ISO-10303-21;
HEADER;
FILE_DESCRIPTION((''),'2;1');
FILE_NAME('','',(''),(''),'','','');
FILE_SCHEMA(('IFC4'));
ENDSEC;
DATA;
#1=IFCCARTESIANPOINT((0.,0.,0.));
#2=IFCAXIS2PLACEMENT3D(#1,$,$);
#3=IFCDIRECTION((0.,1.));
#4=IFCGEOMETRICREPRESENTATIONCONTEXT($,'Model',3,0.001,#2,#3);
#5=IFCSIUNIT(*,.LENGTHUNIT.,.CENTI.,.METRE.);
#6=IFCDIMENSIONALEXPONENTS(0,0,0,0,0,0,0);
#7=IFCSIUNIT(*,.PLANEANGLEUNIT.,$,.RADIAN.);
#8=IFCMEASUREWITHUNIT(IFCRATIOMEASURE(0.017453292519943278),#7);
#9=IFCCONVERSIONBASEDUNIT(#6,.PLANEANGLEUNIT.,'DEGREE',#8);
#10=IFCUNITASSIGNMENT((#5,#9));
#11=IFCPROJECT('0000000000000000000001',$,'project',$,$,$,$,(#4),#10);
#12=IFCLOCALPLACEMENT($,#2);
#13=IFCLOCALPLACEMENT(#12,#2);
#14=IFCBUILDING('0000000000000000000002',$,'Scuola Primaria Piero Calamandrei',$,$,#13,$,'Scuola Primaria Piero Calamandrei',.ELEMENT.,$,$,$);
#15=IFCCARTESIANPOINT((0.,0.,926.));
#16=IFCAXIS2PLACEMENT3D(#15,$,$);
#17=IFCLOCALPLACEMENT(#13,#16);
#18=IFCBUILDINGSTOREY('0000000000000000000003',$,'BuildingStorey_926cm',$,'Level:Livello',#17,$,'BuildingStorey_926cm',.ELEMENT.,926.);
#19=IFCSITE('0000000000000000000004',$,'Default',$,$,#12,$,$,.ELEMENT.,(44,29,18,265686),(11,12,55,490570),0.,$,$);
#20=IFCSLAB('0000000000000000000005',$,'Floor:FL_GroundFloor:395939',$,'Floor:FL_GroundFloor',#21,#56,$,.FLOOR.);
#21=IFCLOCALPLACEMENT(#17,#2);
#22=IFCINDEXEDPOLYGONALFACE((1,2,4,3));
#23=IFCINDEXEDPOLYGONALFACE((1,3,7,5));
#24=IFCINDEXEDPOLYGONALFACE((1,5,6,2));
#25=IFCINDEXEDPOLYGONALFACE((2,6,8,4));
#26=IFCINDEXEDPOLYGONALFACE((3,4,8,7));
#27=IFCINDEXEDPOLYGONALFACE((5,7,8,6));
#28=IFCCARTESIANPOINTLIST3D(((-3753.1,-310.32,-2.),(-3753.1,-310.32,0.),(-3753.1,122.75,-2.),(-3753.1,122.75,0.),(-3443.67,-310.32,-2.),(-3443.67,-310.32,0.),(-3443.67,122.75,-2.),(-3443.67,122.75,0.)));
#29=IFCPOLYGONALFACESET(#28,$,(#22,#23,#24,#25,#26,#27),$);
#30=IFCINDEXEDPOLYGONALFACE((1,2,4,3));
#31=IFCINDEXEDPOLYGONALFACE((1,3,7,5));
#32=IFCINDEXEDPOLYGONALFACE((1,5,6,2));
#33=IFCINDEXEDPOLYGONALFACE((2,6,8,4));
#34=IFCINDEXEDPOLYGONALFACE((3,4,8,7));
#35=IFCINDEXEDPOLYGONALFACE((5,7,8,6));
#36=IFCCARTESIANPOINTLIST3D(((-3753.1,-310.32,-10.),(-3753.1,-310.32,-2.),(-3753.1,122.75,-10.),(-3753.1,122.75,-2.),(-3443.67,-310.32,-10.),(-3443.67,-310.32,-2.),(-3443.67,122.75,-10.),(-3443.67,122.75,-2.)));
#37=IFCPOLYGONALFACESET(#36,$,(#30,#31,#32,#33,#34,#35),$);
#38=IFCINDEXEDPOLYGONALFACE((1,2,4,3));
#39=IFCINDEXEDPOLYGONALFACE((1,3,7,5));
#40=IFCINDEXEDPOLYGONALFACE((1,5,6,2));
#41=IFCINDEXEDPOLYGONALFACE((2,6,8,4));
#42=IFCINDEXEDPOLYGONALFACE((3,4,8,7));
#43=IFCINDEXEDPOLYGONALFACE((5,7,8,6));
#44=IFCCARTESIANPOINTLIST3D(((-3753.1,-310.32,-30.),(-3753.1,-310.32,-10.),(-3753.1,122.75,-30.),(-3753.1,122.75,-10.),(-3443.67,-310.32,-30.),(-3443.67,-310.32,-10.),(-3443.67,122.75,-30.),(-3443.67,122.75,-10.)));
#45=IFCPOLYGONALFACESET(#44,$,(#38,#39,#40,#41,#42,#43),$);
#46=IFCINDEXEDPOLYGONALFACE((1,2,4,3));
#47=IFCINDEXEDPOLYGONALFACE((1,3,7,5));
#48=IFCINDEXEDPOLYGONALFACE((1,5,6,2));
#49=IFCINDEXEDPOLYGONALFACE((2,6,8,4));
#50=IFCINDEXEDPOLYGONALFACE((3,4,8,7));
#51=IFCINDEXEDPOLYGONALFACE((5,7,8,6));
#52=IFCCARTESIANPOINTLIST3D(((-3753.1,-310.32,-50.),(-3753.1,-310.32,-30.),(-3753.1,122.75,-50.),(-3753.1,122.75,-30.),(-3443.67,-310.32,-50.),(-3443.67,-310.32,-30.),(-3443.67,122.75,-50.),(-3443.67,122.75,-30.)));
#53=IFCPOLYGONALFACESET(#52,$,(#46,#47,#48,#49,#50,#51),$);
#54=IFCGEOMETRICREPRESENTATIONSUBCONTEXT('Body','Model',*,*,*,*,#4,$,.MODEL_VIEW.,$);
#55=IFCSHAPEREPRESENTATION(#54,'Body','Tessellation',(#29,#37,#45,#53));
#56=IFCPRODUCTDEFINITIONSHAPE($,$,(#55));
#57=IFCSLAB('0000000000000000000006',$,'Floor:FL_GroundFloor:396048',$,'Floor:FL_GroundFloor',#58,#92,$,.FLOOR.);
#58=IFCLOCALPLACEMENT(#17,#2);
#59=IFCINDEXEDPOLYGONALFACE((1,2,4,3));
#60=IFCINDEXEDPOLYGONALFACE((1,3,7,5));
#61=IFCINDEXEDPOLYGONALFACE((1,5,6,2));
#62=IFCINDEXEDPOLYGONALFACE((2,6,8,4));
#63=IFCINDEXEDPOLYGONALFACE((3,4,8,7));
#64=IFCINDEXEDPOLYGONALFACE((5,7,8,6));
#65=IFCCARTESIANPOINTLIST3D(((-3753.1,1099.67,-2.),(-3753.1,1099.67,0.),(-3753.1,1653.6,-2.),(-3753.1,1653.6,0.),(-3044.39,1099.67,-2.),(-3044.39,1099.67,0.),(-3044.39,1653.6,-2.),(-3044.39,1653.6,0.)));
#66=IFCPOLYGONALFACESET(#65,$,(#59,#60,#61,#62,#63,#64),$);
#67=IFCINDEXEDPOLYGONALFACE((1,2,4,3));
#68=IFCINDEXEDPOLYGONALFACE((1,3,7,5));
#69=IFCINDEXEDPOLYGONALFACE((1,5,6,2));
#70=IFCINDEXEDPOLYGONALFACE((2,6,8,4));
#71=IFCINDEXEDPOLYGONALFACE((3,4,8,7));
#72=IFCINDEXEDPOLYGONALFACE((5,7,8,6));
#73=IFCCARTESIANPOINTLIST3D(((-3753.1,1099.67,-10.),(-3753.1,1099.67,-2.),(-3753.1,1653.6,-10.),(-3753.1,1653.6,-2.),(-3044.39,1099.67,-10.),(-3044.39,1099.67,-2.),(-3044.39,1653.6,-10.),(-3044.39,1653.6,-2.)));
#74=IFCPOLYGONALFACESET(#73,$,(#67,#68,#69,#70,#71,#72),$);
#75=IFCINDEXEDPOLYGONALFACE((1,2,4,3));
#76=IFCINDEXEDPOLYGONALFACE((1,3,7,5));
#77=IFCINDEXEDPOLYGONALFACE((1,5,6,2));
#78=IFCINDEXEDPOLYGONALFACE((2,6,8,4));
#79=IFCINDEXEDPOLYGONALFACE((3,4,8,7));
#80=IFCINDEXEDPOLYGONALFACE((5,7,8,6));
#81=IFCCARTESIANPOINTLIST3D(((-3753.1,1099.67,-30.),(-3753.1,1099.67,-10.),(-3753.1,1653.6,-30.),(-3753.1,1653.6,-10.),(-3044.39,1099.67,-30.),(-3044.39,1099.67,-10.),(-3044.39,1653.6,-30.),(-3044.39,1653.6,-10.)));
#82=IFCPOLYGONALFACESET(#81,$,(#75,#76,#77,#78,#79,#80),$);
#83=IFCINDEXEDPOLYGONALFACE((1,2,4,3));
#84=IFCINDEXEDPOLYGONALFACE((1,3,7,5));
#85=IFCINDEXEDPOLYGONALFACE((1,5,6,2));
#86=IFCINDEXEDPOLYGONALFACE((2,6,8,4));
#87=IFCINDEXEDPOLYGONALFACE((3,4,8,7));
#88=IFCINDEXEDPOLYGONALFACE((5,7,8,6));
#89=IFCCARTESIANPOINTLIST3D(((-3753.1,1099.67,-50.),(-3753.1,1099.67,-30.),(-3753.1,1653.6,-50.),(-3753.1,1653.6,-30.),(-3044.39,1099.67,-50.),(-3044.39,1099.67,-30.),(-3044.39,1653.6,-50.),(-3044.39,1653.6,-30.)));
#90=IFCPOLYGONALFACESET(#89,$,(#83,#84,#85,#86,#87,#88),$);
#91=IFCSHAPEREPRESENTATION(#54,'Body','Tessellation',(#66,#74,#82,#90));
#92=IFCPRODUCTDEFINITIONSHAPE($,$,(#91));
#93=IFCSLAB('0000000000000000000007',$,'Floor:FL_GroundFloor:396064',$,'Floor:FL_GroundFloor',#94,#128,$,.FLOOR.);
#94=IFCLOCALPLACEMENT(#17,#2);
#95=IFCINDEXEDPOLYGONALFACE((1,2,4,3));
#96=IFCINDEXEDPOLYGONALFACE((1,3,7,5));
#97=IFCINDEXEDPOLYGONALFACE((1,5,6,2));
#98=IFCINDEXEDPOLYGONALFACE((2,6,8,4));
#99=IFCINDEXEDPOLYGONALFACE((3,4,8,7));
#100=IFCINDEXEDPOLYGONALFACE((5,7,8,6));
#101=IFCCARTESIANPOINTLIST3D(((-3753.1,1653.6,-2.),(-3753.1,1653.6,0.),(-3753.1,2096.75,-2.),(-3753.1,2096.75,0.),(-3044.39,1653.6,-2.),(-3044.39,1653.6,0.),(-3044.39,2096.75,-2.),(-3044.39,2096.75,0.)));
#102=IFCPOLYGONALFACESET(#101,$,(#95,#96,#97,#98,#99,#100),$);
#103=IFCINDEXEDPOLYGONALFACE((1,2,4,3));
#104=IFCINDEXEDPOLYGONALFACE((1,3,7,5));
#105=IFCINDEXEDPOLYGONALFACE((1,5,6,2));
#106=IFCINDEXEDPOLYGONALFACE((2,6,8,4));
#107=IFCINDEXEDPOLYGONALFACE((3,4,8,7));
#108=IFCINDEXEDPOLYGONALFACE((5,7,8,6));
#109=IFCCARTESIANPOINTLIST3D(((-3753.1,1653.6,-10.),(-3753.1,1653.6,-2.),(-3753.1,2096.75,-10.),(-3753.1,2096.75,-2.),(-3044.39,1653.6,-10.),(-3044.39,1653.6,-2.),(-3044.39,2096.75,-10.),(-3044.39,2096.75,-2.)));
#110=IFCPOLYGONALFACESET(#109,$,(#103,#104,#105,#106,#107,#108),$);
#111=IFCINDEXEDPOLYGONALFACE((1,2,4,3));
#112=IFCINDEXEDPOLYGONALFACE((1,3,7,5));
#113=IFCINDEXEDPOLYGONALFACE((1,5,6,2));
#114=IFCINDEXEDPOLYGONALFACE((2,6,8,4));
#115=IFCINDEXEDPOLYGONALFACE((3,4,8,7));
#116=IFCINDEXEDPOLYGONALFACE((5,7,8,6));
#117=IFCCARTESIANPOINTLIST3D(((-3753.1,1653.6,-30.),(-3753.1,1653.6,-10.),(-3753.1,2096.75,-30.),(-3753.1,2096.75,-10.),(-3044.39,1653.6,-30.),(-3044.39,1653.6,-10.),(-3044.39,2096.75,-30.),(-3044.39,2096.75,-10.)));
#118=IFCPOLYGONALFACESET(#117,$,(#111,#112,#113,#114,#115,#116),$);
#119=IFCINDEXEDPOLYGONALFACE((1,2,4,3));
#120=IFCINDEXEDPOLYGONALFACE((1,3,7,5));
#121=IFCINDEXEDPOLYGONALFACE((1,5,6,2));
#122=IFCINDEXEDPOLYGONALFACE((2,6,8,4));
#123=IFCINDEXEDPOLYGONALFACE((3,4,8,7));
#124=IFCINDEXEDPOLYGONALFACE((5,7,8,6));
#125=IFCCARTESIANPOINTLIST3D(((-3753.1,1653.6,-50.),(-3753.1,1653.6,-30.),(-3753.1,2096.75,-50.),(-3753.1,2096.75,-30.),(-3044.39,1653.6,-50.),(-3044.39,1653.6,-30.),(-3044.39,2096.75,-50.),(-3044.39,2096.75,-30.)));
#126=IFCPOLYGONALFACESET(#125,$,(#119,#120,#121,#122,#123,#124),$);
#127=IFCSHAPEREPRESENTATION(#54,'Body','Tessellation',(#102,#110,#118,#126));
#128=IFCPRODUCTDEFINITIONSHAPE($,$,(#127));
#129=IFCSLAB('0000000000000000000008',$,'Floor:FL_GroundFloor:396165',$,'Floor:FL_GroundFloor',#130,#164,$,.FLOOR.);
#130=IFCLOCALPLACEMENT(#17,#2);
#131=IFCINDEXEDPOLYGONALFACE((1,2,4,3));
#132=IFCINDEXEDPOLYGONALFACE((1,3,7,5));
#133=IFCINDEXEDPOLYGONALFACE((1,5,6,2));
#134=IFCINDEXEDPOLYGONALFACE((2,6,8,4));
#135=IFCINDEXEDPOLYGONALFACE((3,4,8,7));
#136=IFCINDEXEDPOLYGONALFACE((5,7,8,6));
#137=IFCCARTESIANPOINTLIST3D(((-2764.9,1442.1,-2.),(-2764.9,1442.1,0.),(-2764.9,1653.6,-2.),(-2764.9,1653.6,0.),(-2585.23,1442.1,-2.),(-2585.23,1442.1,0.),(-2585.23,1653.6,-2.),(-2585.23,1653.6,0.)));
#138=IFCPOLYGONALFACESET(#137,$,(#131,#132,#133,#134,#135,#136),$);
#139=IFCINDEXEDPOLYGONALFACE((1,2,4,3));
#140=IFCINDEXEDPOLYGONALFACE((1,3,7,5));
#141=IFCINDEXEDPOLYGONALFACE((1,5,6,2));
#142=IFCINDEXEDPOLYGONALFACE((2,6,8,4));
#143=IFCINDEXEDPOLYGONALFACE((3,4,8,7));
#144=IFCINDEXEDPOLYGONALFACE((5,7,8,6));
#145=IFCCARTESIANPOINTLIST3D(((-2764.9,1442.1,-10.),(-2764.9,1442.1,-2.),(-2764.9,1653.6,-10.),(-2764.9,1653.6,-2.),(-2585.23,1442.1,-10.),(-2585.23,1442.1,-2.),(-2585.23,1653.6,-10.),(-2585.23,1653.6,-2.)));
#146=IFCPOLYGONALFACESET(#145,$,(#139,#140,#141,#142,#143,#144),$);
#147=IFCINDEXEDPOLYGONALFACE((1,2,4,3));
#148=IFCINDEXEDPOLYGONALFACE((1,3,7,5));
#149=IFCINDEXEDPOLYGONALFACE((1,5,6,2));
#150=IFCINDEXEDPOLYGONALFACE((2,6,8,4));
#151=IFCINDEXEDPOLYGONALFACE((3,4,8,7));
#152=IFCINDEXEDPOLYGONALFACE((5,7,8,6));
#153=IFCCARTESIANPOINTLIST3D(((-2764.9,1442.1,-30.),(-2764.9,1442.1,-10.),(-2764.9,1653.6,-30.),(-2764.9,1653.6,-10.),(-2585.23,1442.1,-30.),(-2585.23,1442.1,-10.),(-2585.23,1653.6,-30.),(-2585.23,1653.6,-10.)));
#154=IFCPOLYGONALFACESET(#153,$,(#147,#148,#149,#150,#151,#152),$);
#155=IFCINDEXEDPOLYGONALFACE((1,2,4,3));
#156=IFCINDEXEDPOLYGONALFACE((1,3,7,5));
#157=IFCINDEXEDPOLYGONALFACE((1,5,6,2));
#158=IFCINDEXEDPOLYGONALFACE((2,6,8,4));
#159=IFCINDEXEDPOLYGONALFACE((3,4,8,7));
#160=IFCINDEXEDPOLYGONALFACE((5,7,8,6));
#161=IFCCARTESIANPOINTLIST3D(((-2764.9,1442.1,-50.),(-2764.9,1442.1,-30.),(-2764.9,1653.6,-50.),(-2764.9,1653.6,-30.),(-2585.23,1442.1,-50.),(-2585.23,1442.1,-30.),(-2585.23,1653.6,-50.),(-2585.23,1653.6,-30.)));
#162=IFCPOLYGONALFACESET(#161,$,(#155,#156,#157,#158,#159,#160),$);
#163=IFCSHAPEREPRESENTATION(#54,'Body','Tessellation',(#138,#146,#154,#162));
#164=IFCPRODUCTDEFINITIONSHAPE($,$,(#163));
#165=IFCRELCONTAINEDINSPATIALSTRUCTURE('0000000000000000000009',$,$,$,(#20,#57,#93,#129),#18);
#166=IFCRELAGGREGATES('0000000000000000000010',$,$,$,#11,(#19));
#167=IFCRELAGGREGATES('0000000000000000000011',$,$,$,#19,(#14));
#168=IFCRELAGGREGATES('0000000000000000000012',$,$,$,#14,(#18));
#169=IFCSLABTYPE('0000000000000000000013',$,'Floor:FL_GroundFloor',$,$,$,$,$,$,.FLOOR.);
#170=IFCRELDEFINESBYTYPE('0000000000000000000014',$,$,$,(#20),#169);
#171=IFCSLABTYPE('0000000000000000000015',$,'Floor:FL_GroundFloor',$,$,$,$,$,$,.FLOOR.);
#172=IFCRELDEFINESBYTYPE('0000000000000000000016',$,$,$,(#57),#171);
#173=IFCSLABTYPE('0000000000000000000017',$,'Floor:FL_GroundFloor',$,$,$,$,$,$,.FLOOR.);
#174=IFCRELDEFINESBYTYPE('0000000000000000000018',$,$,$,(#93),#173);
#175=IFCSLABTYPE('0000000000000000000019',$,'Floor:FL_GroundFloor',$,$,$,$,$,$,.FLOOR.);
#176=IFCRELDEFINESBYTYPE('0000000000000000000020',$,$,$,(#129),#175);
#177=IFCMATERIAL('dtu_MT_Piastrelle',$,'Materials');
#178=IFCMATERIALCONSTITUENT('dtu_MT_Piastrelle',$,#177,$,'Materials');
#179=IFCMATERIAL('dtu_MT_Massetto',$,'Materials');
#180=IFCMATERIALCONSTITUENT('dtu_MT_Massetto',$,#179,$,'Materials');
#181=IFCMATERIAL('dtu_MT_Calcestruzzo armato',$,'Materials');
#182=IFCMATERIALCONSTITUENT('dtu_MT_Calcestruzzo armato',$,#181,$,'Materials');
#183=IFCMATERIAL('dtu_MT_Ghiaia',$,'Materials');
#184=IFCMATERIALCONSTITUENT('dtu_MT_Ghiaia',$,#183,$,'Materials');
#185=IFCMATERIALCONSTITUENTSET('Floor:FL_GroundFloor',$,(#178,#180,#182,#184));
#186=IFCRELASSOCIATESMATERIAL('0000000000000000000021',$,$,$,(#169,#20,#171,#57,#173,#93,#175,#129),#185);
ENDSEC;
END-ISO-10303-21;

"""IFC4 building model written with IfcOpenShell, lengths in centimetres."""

from ifc_helpers import new_model, entity, si_unit, converted_unit, direction, frame, origin, place, context, subcontext, project, spatial, indexed_curve, outline, extrude, material, constituent, constituent_set, type_object, element, save


model = new_model("IFC4")

# Units and contexts
model_context = context("Model", 3, precision=0.001, world=origin(), true_north=direction((0.0, 1.0)))
body_context = subcontext(model_context, "Body", "Model", "MODEL_VIEW")
ifc_project = project(units=[si_unit("LENGTHUNIT", "METRE", prefix="CENTI"), converted_unit("PLANEANGLEUNIT", "DEGREE", entity("IfcRatioMeasure", 0.017453292519943278), si_unit("PLANEANGLEUNIT", "RADIAN"), dimensions=[0, 0, 0, 0, 0, 0, 0])], contexts=[model_context])

# Site, building, storey
site_placement = place(None, origin())
site = spatial("IfcSite", under=ifc_project, at=site_placement, Name="Default", CompositionType="ELEMENT", RefLatitude=(44, 29, 18, 265686), RefLongitude=(11, 12, 55, 490570), RefElevation=0.0)
building_placement = place(site_placement, origin())
building = spatial("IfcBuilding", under=site, at=building_placement, Name="Scuola Primaria Piero Calamandrei", LongName="Scuola Primaria Piero Calamandrei", CompositionType="ELEMENT")
storey_placement = place(building_placement, frame((0.0, 0.0, 926.0)))
storey = spatial("IfcBuildingStorey", under=building, at=storey_placement, Name="BuildingStorey_926cm", ObjectType="Level:Livello", LongName="BuildingStorey_926cm", CompositionType="ELEMENT", Elevation=926.0)

# Slabs
ifc_material_1 = material(Name="dtu_MT_Piastrelle", Category="Materials")
ifc_constituent_1 = constituent(ifc_material_1, Name="dtu_MT_Piastrelle", Category="Materials")
ifc_material_2 = material(Name="dtu_MT_Massetto", Category="Materials")
ifc_constituent_2 = constituent(ifc_material_2, Name="dtu_MT_Massetto", Category="Materials")
ifc_material_3 = material(Name="dtu_MT_Calcestruzzo armato", Category="Materials")
ifc_constituent_3 = constituent(ifc_material_3, Name="dtu_MT_Calcestruzzo armato", Category="Materials")
ifc_material_4 = material(Name="dtu_MT_Ghiaia", Category="Materials")
ifc_constituent_4 = constituent(ifc_material_4, Name="dtu_MT_Ghiaia", Category="Materials")
ifc_constituent_set_1 = constituent_set(constituents=[ifc_constituent_1, ifc_constituent_2, ifc_constituent_3, ifc_constituent_4], Name="Floor:FL_GroundFloor")
slab_type_1 = type_object("IfcSlabType", Name="Floor:FL_GroundFloor", PredefinedType="FLOOR", material=ifc_constituent_set_1)
slab_1_placement = place(storey_placement, origin())
element("IfcSlab", 1, at=slab_1_placement, inside=storey, type_object=slab_type_1, material=ifc_constituent_set_1, Name="Floor:FL_GroundFloor:395939", ObjectType="Floor:FL_GroundFloor", PredefinedType="FLOOR", context=body_context, shape_type="SweptSolid", body=[
    extrude(outline(indexed_curve([(-216.54, -154.72), (216.54, -154.72), (216.54, 154.72), (-216.54, 154.72), (-216.54, -154.72)], self_intersect=False)), frame((-3598.38, -93.79, -2.0), z_axis=(0.0, 0.0, 1.0), x_axis=(0.0, 1.0, 0.0)), (0.0, 0.0, 1.0), 2.0),
    extrude(outline(indexed_curve([(-216.54, -154.72), (216.54, -154.72), (216.54, 154.72), (-216.54, 154.72), (-216.54, -154.72)], self_intersect=False)), frame((-3598.38, -93.79, -10.0), z_axis=(0.0, 0.0, 1.0), x_axis=(0.0, 1.0, 0.0)), (0.0, 0.0, 1.0), 8.0),
    extrude(outline(indexed_curve([(-216.54, -154.72), (216.54, -154.72), (216.54, 154.72), (-216.54, 154.72), (-216.54, -154.72)], self_intersect=False)), frame((-3598.38, -93.79, -30.0), z_axis=(0.0, 0.0, 1.0), x_axis=(0.0, 1.0, 0.0)), (0.0, 0.0, 1.0), 20.0),
    extrude(outline(indexed_curve([(-216.54, -154.72), (216.54, -154.72), (216.54, 154.72), (-216.54, 154.72), (-216.54, -154.72)], self_intersect=False)), frame((-3598.38, -93.79, -50.0), z_axis=(0.0, 0.0, 1.0), x_axis=(0.0, 1.0, 0.0)), (0.0, 0.0, 1.0), 20.0),
])
slab_type_2 = type_object("IfcSlabType", Name="Floor:FL_GroundFloor", PredefinedType="FLOOR", material=ifc_constituent_set_1)
slab_2_placement = place(storey_placement, origin())
element("IfcSlab", 2, at=slab_2_placement, inside=storey, type_object=slab_type_2, material=ifc_constituent_set_1, Name="Floor:FL_GroundFloor:396048", ObjectType="Floor:FL_GroundFloor", PredefinedType="FLOOR", context=body_context, shape_type="SweptSolid", body=[
    extrude(outline(indexed_curve([(-276.96, -354.35), (276.96, -354.35), (276.96, 354.35), (-276.96, 354.35), (-276.96, -354.35)], self_intersect=False)), frame((-3398.75, 1376.64, -2.0), z_axis=(0.0, 0.0, 1.0), x_axis=(0.0, -1.0, 0.0)), (0.0, 0.0, 1.0), 2.0),
    extrude(outline(indexed_curve([(-276.96, -354.35), (276.96, -354.35), (276.96, 354.35), (-276.96, 354.35), (-276.96, -354.35)], self_intersect=False)), frame((-3398.75, 1376.64, -10.0), z_axis=(0.0, 0.0, 1.0), x_axis=(0.0, -1.0, 0.0)), (0.0, 0.0, 1.0), 8.0),
    extrude(outline(indexed_curve([(-276.96, -354.35), (276.96, -354.35), (276.96, 354.35), (-276.96, 354.35), (-276.96, -354.35)], self_intersect=False)), frame((-3398.75, 1376.64, -30.0), z_axis=(0.0, 0.0, 1.0), x_axis=(0.0, -1.0, 0.0)), (0.0, 0.0, 1.0), 20.0),
    extrude(outline(indexed_curve([(-276.96, -354.35), (276.96, -354.35), (276.96, 354.35), (-276.96, 354.35), (-276.96, -354.35)], self_intersect=False)), frame((-3398.75, 1376.64, -50.0), z_axis=(0.0, 0.0, 1.0), x_axis=(0.0, -1.0, 0.0)), (0.0, 0.0, 1.0), 20.0),
])
slab_type_3 = type_object("IfcSlabType", Name="Floor:FL_GroundFloor", PredefinedType="FLOOR", material=ifc_constituent_set_1)
slab_3_placement = place(storey_placement, origin())
element("IfcSlab", 3, at=slab_3_placement, inside=storey, type_object=slab_type_3, material=ifc_constituent_set_1, Name="Floor:FL_GroundFloor:396064", ObjectType="Floor:FL_GroundFloor", PredefinedType="FLOOR", context=body_context, shape_type="SweptSolid", body=[
    extrude(outline(indexed_curve([(-221.57, -354.35), (221.57, -354.35), (221.57, 354.35), (-221.57, 354.35), (-221.57, -354.35)], self_intersect=False)), frame((-3398.75, 1875.17, -2.0), z_axis=(0.0, 0.0, 1.0), x_axis=(0.0, -1.0, 0.0)), (0.0, 0.0, 1.0), 2.0),
    extrude(outline(indexed_curve([(-221.57, -354.35), (221.57, -354.35), (221.57, 354.35), (-221.57, 354.35), (-221.57, -354.35)], self_intersect=False)), frame((-3398.75, 1875.17, -10.0), z_axis=(0.0, 0.0, 1.0), x_axis=(0.0, -1.0, 0.0)), (0.0, 0.0, 1.0), 8.0),
    extrude(outline(indexed_curve([(-221.57, -354.35), (221.57, -354.35), (221.57, 354.35), (-221.57, 354.35), (-221.57, -354.35)], self_intersect=False)), frame((-3398.75, 1875.17, -30.0), z_axis=(0.0, 0.0, 1.0), x_axis=(0.0, -1.0, 0.0)), (0.0, 0.0, 1.0), 20.0),
    extrude(outline(indexed_curve([(-221.57, -354.35), (221.57, -354.35), (221.57, 354.35), (-221.57, 354.35), (-221.57, -354.35)], self_intersect=False)), frame((-3398.75, 1875.17, -50.0), z_axis=(0.0, 0.0, 1.0), x_axis=(0.0, -1.0, 0.0)), (0.0, 0.0, 1.0), 20.0),
])
slab_type_4 = type_object("IfcSlabType", Name="Floor:FL_GroundFloor", PredefinedType="FLOOR", material=ifc_constituent_set_1)
slab_4_placement = place(storey_placement, origin())
element("IfcSlab", 4, at=slab_4_placement, inside=storey, type_object=slab_type_4, material=ifc_constituent_set_1, Name="Floor:FL_GroundFloor:396165", ObjectType="Floor:FL_GroundFloor", PredefinedType="FLOOR", context=body_context, shape_type="SweptSolid", body=[
    extrude(outline(indexed_curve([(-105.75, -89.84), (105.75, -89.84), (105.75, 89.84), (-105.75, 89.84), (-105.75, -89.84)], self_intersect=False)), frame((-2675.07, 1547.85, -2.0), z_axis=(0.0, 0.0, 1.0), x_axis=(0.0, 1.0, 0.0)), (0.0, 0.0, 1.0), 2.0),
    extrude(outline(indexed_curve([(-105.75, -89.84), (105.75, -89.84), (105.75, 89.84), (-105.75, 89.84), (-105.75, -89.84)], self_intersect=False)), frame((-2675.07, 1547.85, -10.0), z_axis=(0.0, 0.0, 1.0), x_axis=(0.0, 1.0, 0.0)), (0.0, 0.0, 1.0), 8.0),
    extrude(outline(indexed_curve([(-105.75, -89.84), (105.75, -89.84), (105.75, 89.84), (-105.75, 89.84), (-105.75, -89.84)], self_intersect=False)), frame((-2675.07, 1547.85, -30.0), z_axis=(0.0, 0.0, 1.0), x_axis=(0.0, 1.0, 0.0)), (0.0, 0.0, 1.0), 20.0),
    extrude(outline(indexed_curve([(-105.75, -89.84), (105.75, -89.84), (105.75, 89.84), (-105.75, 89.84), (-105.75, -89.84)], self_intersect=False)), frame((-2675.07, 1547.85, -50.0), z_axis=(0.0, 0.0, 1.0), x_axis=(0.0, 1.0, 0.0)), (0.0, 0.0, 1.0), 20.0),
])

save(model, "model.ifc")
